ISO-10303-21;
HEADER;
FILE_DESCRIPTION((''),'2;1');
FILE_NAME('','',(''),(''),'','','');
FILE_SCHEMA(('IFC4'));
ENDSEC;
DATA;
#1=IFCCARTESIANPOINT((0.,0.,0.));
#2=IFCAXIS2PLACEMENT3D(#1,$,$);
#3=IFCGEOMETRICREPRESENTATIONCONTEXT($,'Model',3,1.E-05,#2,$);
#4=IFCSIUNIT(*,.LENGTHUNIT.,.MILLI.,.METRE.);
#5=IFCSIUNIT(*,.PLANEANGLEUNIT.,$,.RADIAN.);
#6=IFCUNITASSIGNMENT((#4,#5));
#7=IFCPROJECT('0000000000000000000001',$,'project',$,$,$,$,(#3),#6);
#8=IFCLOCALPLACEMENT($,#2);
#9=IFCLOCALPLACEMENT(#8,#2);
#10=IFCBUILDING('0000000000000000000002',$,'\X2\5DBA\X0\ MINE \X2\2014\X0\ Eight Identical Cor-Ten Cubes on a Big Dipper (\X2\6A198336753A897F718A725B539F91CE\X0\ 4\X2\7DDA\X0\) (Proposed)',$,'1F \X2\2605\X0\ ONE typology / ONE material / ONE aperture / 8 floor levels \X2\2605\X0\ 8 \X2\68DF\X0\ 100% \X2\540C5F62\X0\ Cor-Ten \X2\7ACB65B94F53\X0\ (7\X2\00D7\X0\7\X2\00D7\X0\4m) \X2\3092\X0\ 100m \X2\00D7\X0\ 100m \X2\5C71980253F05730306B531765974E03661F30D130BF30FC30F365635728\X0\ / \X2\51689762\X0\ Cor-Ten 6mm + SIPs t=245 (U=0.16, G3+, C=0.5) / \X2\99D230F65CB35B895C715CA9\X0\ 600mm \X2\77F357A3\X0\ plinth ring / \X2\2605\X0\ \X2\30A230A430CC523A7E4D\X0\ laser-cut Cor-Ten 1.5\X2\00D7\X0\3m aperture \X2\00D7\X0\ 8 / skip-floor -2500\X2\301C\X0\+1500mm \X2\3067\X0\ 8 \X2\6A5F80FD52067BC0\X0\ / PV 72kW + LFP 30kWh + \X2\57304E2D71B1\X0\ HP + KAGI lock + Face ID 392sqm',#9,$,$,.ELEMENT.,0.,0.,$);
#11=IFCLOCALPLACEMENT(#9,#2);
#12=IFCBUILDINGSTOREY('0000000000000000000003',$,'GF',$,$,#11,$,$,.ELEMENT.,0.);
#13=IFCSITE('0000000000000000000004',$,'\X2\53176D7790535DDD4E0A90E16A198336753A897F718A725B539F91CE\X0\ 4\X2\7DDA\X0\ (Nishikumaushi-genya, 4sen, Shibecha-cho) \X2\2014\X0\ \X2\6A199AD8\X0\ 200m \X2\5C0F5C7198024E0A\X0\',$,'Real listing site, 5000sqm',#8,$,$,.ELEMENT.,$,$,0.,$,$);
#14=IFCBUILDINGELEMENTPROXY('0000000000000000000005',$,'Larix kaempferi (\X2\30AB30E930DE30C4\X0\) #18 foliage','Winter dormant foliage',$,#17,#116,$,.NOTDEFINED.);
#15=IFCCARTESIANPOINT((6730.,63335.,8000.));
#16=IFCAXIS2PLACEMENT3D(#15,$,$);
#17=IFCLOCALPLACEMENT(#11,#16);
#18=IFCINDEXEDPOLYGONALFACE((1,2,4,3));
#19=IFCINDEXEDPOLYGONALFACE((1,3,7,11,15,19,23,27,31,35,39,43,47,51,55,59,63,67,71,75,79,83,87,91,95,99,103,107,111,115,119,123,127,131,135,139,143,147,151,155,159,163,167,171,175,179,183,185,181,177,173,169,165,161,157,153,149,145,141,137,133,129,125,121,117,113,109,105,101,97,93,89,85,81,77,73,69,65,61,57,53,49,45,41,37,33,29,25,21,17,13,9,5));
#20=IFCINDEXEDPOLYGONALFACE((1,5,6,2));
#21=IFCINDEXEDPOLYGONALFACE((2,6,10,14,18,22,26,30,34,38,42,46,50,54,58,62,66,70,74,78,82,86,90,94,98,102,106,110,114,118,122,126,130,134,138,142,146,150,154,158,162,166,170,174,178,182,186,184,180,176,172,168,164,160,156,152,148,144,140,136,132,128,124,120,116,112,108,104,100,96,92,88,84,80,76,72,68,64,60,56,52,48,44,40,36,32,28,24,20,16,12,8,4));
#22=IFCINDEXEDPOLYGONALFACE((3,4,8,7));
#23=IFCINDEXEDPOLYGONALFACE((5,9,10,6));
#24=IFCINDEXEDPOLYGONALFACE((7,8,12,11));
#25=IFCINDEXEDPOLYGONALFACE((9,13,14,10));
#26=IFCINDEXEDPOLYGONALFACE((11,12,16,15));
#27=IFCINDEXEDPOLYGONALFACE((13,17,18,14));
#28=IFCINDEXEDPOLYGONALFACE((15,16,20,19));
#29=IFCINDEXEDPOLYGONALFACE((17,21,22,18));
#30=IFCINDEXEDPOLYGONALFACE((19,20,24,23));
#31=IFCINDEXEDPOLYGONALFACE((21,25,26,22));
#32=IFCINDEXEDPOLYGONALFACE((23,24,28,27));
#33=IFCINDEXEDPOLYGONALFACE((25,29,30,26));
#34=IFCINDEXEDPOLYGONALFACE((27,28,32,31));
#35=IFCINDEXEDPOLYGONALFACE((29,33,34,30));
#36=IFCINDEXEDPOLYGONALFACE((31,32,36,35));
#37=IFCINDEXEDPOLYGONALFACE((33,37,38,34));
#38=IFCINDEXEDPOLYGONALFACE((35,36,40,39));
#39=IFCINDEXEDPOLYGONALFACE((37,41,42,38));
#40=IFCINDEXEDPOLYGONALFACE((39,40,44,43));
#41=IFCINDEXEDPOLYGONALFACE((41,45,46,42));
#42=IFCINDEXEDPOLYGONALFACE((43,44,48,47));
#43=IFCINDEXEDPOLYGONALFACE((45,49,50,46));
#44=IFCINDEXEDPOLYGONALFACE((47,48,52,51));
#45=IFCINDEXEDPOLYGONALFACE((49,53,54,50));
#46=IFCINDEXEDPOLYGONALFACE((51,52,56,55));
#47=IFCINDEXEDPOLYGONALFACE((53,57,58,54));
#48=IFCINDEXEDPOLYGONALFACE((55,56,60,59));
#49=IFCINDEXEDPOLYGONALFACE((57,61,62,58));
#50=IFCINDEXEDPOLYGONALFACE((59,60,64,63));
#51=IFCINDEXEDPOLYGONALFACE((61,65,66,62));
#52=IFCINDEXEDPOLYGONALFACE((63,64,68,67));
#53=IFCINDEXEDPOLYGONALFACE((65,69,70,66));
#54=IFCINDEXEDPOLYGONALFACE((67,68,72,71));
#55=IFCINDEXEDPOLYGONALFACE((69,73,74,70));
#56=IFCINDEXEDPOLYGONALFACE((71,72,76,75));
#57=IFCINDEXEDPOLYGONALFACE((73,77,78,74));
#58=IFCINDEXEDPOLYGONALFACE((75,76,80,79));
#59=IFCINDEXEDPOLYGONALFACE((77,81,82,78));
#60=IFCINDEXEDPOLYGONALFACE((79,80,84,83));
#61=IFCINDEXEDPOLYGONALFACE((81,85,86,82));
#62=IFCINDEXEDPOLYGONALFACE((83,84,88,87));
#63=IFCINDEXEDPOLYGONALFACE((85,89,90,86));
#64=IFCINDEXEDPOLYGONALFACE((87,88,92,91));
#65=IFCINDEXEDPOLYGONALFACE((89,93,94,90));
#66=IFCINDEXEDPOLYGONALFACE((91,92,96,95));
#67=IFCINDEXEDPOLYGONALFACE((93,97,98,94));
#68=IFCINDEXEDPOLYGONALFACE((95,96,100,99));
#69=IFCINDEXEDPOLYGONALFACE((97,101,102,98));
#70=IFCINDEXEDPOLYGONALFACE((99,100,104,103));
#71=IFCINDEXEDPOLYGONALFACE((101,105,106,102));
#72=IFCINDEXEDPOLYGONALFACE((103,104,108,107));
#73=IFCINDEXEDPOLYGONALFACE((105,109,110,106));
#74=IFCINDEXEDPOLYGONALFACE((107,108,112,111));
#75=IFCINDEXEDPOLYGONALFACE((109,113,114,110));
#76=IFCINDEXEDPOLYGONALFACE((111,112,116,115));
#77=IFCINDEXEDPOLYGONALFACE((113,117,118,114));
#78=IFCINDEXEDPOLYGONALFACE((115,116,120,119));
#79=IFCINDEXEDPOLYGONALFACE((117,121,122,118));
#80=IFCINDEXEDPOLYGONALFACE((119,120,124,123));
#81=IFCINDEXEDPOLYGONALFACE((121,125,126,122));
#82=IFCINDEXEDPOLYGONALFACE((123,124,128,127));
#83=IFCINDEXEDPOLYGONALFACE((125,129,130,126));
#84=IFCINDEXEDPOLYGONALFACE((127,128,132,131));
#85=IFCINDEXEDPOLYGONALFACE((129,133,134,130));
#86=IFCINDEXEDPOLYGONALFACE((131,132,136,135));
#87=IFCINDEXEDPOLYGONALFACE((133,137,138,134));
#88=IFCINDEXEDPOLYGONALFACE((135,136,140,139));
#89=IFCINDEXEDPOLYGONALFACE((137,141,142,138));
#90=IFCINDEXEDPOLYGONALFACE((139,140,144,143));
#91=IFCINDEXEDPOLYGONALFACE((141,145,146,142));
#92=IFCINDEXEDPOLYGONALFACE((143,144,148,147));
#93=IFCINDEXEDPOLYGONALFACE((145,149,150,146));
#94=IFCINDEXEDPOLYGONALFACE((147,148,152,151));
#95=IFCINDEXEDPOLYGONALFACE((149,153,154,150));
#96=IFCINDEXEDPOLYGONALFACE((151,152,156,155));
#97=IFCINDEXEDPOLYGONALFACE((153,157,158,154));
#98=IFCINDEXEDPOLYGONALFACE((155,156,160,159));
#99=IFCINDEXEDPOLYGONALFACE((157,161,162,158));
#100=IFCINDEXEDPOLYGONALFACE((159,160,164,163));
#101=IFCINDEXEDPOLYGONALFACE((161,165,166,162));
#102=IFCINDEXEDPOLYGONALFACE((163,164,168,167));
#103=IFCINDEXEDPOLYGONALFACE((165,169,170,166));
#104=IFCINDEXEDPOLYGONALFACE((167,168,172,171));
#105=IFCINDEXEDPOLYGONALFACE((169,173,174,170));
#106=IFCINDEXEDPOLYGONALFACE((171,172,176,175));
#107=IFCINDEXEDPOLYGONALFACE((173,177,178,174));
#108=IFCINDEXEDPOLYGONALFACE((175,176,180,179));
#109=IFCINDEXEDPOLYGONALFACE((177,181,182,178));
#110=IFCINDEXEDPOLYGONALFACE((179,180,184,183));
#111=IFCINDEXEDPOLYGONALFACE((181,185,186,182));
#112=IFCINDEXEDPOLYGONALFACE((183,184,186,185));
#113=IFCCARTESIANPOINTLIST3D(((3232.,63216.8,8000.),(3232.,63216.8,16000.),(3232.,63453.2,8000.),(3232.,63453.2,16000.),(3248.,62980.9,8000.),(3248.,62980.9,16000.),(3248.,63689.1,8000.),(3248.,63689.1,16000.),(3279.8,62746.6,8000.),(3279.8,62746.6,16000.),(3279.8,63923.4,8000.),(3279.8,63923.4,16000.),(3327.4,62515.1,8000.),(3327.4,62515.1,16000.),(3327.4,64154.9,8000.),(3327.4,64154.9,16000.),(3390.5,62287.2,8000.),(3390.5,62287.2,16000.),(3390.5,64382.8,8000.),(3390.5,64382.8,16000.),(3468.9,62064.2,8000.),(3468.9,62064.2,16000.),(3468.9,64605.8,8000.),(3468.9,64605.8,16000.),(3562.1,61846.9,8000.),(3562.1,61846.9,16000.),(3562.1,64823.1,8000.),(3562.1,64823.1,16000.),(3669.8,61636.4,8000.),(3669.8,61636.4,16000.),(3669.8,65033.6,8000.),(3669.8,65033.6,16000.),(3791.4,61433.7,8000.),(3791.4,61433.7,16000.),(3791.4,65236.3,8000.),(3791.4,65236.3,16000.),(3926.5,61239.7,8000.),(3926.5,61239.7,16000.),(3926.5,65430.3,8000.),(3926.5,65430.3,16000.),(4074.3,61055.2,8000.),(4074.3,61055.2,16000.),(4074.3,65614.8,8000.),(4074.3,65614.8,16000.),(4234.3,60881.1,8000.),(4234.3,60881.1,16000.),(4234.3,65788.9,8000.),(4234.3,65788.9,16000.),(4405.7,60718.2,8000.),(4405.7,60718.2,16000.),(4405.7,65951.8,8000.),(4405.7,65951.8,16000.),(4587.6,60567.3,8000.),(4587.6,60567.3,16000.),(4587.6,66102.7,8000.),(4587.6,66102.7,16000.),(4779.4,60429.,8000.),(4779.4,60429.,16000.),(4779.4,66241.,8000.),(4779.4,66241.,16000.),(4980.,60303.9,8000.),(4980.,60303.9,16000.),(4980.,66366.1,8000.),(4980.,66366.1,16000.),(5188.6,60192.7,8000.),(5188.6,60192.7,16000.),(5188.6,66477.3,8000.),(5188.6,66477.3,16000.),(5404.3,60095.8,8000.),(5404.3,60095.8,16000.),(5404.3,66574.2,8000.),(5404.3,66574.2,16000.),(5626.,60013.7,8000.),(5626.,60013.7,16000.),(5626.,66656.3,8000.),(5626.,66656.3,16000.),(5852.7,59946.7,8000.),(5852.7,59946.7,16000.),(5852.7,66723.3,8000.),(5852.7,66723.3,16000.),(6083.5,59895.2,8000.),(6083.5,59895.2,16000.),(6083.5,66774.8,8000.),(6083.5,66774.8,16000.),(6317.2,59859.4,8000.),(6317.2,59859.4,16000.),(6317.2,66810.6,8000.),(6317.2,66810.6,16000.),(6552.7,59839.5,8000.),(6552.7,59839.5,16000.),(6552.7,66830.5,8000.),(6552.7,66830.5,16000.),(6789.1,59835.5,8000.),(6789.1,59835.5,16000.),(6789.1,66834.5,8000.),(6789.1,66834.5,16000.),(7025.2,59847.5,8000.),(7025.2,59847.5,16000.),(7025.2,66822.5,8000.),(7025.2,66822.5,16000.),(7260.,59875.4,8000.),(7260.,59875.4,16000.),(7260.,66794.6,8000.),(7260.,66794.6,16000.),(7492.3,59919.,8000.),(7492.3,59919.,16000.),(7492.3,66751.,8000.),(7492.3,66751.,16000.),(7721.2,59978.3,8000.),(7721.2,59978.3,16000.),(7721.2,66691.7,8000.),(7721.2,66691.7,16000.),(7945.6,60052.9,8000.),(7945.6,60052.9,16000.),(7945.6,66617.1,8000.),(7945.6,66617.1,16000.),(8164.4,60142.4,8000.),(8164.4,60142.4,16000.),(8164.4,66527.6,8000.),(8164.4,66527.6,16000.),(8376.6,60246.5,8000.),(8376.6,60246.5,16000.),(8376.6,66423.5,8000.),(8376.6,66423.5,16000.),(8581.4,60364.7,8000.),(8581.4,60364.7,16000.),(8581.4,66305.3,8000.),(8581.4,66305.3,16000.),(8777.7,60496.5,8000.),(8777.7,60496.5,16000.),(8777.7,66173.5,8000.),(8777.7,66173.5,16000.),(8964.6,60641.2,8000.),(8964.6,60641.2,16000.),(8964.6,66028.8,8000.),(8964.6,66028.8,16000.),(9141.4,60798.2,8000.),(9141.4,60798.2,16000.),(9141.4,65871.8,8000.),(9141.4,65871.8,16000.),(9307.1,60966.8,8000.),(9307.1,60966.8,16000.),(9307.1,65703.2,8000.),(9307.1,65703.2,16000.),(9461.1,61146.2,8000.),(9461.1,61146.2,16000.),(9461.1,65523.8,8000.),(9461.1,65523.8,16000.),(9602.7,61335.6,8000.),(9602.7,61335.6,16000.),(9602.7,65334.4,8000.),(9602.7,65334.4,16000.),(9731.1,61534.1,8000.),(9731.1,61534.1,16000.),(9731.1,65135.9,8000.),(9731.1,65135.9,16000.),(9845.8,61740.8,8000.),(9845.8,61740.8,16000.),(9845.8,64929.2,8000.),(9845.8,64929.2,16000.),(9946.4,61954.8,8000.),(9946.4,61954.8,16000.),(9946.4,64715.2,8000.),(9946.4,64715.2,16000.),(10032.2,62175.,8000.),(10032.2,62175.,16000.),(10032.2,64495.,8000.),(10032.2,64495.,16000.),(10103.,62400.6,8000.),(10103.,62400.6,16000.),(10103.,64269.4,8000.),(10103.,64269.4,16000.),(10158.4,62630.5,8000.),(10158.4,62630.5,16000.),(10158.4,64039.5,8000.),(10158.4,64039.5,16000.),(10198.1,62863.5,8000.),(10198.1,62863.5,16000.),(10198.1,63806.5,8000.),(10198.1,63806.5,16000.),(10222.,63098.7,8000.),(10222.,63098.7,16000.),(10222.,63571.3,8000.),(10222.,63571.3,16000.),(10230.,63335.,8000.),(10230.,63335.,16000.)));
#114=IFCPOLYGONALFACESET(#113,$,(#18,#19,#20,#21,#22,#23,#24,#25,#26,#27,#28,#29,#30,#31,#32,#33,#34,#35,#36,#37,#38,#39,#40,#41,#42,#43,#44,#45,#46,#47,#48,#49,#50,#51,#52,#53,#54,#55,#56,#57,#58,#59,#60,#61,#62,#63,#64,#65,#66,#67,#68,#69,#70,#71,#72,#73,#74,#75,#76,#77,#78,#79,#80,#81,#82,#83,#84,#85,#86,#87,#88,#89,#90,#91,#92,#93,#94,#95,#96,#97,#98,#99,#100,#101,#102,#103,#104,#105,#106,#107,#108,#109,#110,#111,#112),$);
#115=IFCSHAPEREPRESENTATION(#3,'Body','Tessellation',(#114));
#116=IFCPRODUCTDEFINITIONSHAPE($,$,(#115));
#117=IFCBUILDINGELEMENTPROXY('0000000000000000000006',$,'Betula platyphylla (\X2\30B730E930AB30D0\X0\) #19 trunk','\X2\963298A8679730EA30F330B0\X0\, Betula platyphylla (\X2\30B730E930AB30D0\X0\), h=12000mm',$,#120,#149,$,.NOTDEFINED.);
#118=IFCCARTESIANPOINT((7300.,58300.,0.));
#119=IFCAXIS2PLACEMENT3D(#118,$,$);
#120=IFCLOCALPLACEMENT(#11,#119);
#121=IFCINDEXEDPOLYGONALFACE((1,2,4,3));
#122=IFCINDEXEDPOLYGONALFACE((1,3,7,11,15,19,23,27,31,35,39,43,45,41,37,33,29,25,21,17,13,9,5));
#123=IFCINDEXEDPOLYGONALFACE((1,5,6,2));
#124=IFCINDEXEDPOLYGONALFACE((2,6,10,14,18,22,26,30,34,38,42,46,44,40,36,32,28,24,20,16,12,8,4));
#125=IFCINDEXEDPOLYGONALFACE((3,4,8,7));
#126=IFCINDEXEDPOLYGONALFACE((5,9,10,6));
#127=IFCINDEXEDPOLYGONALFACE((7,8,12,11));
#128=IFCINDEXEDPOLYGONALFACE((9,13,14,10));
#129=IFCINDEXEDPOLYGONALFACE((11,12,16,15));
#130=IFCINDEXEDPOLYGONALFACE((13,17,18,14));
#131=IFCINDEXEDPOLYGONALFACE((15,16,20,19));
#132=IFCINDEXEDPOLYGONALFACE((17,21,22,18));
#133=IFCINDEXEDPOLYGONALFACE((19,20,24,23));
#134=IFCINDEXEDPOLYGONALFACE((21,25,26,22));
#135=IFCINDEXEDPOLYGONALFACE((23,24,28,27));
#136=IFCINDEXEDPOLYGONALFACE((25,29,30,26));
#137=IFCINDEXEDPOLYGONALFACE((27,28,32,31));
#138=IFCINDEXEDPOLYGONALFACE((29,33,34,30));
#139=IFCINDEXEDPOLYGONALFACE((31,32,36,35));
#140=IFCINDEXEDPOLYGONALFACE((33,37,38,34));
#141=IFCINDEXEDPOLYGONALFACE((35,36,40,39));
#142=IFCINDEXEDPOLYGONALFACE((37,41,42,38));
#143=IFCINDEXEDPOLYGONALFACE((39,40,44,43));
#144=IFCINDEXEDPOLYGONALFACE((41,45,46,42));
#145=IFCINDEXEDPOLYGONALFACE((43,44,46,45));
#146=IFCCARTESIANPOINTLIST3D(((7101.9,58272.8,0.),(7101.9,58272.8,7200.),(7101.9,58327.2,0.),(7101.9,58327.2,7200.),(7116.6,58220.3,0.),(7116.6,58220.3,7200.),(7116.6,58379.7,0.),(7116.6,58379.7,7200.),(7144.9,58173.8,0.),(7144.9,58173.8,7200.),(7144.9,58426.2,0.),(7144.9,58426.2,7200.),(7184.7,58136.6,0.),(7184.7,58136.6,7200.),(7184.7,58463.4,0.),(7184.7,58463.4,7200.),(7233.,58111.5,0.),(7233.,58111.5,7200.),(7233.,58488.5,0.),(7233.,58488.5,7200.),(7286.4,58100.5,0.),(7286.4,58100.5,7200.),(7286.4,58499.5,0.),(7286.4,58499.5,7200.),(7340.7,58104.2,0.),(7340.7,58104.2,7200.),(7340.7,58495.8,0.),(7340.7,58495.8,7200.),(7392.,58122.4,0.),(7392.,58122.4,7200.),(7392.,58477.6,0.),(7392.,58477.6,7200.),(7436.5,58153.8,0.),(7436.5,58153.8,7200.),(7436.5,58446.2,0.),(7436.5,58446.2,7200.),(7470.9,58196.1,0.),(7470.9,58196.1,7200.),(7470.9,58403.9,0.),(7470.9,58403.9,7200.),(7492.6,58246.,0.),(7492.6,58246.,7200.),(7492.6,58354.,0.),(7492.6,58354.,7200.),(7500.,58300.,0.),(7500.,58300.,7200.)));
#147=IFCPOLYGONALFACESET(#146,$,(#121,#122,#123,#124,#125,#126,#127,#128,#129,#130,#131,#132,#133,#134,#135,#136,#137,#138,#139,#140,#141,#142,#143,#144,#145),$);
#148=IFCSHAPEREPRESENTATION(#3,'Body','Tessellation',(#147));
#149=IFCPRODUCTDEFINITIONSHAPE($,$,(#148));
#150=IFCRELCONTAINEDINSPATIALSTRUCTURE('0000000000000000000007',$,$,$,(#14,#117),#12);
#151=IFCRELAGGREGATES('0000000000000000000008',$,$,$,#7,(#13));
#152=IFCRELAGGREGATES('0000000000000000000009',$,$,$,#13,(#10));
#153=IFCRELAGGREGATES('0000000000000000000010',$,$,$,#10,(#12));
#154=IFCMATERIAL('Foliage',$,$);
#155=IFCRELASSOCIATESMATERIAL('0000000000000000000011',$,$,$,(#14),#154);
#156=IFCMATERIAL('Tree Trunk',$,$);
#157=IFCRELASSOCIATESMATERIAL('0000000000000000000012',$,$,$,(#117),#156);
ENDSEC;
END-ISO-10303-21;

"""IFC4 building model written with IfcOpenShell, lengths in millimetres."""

from ifc_helpers import new_model, si_unit, frame, origin, origin_2d, place, context, project, spatial, circle, extrude, material, element, save


model = new_model("IFC4")

# Units and contexts
model_context = context("Model", 3, precision=1e-05, world=origin())
ifc_project = project(units=[si_unit("LENGTHUNIT", "METRE", prefix="MILLI"), si_unit("PLANEANGLEUNIT", "RADIAN")], contexts=[model_context])

# Site, building, storey
site_placement = place(None, origin())
site = spatial("IfcSite", under=ifc_project, at=site_placement, Name="北海道川上郡標茶町西熊牛原野 4線 (Nishikumaushi-genya, 4sen, Shibecha-cho) — 標高 200m 小山頂上", ObjectType="Real listing site, 5000sqm", CompositionType="ELEMENT", RefElevation=0.0)
building_placement = place(site_placement, origin())
building = spatial("IfcBuilding", under=site, at=building_placement, Name="嶺 MINE — Eight Identical Cor-Ten Cubes on a Big Dipper (標茶町西熊牛原野 4線) (Proposed)", ObjectType="1F ★ ONE typology / ONE material / ONE aperture / 8 floor levels ★ 8 棟 100% 同形 Cor-Ten 立方体 (7×7×4m) を 100m × 100m 山頂台地に北斗七星パターン散在 / 全面 Cor-Ten 6mm + SIPs t=245 (U=0.16, G3+, C=0.5) / 駒ヶ岳安山岩 600mm 石垣 plinth ring / ★ アイヌ刺繍 laser-cut Cor-Ten 1.5×3m aperture × 8 / skip-floor -2500〜+1500mm で 8 機能分節 / PV 72kW + LFP 30kWh + 地中熱 HP + KAGI lock + Face ID 392sqm", CompositionType="ELEMENT", ElevationOfRefHeight=0.0, ElevationOfTerrain=0.0)
storey_placement = place(building_placement, origin())
storey = spatial("IfcBuildingStorey", under=building, at=storey_placement, Name="GF", CompositionType="ELEMENT", Elevation=0.0)

# Building element proxies
ifc_material_1 = material(Name="Tree Trunk")
ifc_material_2 = material(Name="Foliage")
proxy_1_placement = place(storey_placement, frame((6730.0, 63335.0, 8000.0)))
element("IfcBuildingElementProxy", 1, at=proxy_1_placement, inside=storey, material=ifc_material_2, Name="Larix kaempferi (カラマツ) #18 foliage", Description="Winter dormant foliage", PredefinedType="NOTDEFINED", context=model_context, shape_type="SweptSolid", body=[
    extrude(circle(Radius=3500.0, at=origin_2d()), frame((6730.0, 63335.0, 8000.0)), (0.0, 0.0, 1.0), 8000.0),
])
proxy_2_placement = place(storey_placement, frame((7300.0, 58300.0, 0.0)))
element("IfcBuildingElementProxy", 2, at=proxy_2_placement, inside=storey, material=ifc_material_1, Name="Betula platyphylla (シラカバ) #19 trunk", Description="防風林リング, Betula platyphylla (シラカバ), h=12000mm", PredefinedType="NOTDEFINED", context=model_context, shape_type="SweptSolid", body=[
    extrude(circle(Radius=200.0, at=origin_2d()), frame((7300.0, 58300.0, 0.0)), (0.0, 0.0, 1.0), 7200.0),
])

save(model, "model.ifc")
